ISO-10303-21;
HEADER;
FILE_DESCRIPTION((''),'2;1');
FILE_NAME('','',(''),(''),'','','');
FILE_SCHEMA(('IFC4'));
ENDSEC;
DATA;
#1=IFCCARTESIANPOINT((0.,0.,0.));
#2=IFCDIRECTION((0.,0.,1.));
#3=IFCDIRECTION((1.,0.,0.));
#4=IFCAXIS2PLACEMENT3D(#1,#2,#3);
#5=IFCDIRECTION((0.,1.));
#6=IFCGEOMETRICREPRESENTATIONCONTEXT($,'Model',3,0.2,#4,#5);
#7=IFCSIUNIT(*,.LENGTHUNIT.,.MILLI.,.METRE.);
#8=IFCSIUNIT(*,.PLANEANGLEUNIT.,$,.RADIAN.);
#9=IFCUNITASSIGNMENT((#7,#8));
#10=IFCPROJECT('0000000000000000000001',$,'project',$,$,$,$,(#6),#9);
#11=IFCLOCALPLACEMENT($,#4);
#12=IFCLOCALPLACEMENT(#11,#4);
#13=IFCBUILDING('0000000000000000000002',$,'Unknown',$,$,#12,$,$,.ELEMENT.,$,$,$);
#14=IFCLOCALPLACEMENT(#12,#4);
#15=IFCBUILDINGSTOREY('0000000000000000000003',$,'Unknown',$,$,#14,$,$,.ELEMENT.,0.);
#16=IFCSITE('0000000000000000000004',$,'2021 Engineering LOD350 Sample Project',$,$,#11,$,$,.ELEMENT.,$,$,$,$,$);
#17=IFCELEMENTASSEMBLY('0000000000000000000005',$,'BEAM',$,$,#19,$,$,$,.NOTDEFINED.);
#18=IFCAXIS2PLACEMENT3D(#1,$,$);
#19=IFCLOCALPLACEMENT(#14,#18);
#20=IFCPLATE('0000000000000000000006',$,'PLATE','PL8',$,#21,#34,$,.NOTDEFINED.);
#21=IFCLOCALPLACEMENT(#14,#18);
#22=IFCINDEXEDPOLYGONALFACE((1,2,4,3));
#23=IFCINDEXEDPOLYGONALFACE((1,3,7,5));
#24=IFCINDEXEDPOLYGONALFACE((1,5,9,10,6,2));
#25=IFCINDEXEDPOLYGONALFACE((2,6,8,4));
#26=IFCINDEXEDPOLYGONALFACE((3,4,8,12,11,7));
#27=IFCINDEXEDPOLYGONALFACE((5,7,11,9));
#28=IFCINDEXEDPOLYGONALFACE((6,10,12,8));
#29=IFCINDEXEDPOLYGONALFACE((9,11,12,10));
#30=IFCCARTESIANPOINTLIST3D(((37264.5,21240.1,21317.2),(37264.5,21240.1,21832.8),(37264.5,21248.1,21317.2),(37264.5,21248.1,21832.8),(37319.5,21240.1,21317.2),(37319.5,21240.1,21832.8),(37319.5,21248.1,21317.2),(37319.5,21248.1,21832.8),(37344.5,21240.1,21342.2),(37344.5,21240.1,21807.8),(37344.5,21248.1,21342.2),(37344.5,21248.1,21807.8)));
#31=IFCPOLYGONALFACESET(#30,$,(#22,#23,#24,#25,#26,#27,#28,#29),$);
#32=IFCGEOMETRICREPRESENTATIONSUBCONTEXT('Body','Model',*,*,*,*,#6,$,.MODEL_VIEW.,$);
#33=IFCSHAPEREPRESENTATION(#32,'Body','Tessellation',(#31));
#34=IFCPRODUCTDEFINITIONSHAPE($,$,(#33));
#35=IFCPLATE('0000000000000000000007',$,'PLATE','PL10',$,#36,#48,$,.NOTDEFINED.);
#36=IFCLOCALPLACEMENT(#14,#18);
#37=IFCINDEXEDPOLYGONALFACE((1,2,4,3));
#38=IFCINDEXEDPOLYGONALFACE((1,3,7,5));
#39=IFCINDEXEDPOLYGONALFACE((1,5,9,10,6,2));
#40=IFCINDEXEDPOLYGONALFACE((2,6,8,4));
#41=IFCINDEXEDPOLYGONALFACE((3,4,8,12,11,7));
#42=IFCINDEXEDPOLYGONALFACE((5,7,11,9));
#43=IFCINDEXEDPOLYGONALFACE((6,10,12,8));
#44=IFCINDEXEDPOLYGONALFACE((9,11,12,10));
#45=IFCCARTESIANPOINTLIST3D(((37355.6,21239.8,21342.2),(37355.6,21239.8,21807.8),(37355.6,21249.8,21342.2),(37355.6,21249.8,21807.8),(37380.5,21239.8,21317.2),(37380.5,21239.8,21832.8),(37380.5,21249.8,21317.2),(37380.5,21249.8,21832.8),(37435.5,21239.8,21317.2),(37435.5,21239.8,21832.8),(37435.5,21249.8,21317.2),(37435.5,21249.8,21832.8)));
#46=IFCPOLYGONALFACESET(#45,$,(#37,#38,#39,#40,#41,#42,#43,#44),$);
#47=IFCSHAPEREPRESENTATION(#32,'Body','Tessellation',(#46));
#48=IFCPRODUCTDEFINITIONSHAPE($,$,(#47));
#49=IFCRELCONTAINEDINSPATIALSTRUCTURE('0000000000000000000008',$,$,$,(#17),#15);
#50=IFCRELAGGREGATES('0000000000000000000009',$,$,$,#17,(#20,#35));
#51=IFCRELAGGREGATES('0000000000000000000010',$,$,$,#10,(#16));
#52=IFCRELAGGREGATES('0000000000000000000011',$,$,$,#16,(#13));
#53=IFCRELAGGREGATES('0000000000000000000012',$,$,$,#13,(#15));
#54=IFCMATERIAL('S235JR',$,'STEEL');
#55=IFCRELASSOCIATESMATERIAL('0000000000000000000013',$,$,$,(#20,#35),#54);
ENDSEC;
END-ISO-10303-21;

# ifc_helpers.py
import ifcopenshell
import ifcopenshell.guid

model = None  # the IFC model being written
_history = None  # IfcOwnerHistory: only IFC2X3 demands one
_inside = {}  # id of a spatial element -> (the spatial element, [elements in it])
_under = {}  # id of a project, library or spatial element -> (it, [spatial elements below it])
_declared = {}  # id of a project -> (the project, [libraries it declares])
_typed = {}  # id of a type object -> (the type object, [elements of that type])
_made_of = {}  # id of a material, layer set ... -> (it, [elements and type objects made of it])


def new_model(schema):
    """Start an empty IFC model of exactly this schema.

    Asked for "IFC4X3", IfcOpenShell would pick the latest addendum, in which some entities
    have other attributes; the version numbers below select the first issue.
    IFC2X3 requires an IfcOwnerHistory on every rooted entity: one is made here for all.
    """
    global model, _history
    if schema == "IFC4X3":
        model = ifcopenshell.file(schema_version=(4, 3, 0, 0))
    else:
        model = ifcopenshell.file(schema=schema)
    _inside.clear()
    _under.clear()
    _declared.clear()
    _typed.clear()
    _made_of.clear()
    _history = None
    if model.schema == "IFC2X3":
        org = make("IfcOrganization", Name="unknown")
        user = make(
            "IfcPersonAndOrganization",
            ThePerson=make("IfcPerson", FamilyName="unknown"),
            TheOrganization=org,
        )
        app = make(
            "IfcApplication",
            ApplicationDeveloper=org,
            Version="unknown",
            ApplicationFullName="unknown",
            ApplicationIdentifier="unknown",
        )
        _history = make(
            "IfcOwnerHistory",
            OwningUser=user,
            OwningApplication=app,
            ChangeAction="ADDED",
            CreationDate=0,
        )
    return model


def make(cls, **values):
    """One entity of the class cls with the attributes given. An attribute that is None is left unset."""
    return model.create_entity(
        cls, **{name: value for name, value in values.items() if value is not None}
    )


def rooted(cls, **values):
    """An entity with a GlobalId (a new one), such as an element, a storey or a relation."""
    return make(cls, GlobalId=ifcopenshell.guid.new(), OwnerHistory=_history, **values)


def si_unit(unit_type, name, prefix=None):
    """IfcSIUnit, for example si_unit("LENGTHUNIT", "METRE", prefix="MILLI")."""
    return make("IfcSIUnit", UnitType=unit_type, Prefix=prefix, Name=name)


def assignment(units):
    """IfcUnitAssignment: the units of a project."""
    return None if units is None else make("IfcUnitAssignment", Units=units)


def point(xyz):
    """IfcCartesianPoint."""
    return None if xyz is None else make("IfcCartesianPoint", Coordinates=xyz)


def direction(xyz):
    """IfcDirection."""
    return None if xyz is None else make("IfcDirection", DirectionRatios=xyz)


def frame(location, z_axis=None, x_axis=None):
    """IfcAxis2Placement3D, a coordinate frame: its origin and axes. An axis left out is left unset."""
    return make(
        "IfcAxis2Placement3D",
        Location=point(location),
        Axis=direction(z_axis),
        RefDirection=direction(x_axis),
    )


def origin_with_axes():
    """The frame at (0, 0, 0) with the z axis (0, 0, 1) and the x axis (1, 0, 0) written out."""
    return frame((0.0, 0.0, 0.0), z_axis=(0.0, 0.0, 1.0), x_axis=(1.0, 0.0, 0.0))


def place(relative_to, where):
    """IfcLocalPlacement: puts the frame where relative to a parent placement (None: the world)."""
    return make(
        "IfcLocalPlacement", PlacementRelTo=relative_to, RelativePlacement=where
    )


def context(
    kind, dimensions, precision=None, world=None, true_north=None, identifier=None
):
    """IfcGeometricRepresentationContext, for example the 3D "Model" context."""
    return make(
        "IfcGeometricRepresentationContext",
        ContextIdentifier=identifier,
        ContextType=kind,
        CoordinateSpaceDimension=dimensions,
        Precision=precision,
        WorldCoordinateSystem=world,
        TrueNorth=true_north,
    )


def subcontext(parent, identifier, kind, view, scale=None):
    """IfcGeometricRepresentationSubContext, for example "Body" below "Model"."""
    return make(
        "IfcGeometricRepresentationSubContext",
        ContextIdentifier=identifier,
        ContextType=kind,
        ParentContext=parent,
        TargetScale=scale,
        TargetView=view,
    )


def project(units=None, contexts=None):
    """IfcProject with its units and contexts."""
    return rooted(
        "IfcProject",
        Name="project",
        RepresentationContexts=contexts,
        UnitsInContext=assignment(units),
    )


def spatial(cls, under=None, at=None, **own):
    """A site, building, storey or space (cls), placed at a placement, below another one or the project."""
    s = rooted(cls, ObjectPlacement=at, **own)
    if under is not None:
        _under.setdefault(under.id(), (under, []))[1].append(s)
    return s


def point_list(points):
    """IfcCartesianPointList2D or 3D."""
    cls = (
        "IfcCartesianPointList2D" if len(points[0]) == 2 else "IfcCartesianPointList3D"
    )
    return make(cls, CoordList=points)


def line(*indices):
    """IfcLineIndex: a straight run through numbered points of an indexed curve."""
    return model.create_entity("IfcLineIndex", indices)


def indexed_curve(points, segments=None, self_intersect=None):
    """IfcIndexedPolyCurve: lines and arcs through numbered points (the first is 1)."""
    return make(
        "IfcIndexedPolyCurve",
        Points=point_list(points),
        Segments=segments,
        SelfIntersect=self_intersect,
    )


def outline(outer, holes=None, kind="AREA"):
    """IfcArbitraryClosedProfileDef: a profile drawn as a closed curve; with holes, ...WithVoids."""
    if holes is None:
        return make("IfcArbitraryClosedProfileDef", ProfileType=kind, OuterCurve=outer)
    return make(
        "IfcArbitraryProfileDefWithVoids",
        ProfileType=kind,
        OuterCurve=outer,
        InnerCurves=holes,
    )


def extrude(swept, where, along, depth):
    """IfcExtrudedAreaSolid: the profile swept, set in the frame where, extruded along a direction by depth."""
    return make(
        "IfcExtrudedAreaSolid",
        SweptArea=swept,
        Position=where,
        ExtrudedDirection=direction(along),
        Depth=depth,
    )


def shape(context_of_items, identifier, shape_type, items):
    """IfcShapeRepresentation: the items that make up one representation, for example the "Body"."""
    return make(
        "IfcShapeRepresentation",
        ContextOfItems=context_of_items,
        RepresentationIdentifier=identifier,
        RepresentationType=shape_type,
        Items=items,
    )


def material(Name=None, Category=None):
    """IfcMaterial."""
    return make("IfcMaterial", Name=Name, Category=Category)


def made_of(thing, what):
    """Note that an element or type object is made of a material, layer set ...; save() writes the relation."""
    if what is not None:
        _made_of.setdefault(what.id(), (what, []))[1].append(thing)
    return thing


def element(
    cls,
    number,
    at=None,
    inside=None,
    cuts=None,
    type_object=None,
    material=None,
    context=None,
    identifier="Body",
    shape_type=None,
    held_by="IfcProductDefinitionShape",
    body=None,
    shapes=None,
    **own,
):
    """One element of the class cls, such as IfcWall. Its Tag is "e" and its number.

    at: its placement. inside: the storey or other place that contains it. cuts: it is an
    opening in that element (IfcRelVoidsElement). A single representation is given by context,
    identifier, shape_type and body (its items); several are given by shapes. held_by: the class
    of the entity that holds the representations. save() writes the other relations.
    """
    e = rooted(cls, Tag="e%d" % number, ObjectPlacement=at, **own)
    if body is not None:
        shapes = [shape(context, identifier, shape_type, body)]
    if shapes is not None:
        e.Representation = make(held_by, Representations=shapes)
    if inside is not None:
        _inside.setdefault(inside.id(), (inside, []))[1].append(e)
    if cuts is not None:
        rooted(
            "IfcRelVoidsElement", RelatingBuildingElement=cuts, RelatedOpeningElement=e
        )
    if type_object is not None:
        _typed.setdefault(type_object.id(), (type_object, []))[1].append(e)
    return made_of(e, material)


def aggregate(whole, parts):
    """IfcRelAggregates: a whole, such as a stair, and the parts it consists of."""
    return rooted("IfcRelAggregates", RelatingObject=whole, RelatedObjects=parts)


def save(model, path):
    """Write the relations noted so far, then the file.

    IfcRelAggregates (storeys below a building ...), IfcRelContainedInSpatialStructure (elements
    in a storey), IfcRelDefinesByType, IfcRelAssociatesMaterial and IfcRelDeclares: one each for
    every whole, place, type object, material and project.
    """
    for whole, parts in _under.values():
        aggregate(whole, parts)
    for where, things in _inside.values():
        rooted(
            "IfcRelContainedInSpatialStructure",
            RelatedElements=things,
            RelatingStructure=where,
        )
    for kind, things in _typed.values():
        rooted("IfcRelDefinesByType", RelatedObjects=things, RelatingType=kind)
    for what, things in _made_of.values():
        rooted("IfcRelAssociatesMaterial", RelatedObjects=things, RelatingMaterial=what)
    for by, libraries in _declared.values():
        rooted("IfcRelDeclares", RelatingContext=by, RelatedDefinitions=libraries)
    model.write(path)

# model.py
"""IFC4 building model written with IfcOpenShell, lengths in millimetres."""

from ifc_helpers import new_model, si_unit, direction, frame, origin_with_axes, place, context, subcontext, project, spatial, line, indexed_curve, outline, extrude, material, element, aggregate, save


model = new_model("IFC4")

# Units and contexts
model_context = context("Model", 3, precision=0.2, world=origin_with_axes(), true_north=direction((0.0, 1.0)))
body_context = subcontext(model_context, "Body", "Model", "MODEL_VIEW")
ifc_project = project(units=[si_unit("LENGTHUNIT", "METRE", prefix="MILLI"), si_unit("PLANEANGLEUNIT", "RADIAN")], contexts=[model_context])

# Site, building, storey
site_placement = place(None, origin_with_axes())
site = spatial("IfcSite", under=ifc_project, at=site_placement, Name="2021 Engineering LOD350 Sample Project", CompositionType="ELEMENT")
building_placement = place(site_placement, origin_with_axes())
building = spatial("IfcBuilding", under=site, at=building_placement, Name="Unknown", CompositionType="ELEMENT")
storey_placement = place(building_placement, origin_with_axes())
storey = spatial("IfcBuildingStorey", under=building, at=storey_placement, Name="Unknown", CompositionType="ELEMENT", Elevation=0.0)

# Shared definitions
ifc_material_1 = material(Name="S235JR", Category="STEEL")

# Element assembly
assembly_1_placement = place(storey_placement, frame((37350.0, 18600.0, 21575.0), z_axis=(1.0, 0.0, 0.0), x_axis=(0.0, 1.0, 0.0)))
assembly_1 = element("IfcElementAssembly", 1, at=assembly_1_placement, inside=storey, Name="BEAM", PredefinedType="NOTDEFINED")

# Plates
plate_1_placement = place(assembly_1_placement, frame((2644.1, -257.8, -5.5), z_axis=(1.0, 0.0, 0.0), x_axis=(0.0, 0.0, -1.0)))
plate_1 = element("IfcPlate", 2, at=plate_1_placement, material=ifc_material_1, Name="PLATE", Description="PL8", PredefinedType="NOTDEFINED", context=body_context, shape_type="SolidModel", body=[
    extrude(outline(indexed_curve([(0.0, 25.0), (25.0, 0.0), (80.0, 0.0), (80.0, 515.6), (25.0, 515.6), (0.0, 490.6)], segments=[line(1, 2, 3, 4, 5, 6, 1)])), frame((0.0, 0.0, 4.0), z_axis=(0.0, 0.0, 1.0), x_axis=(1.0, 0.0, 0.0)), (0.0, 0.0, -1.0), 8.0),
])
plate_2_placement = place(assembly_1_placement, frame((2644.8, -257.8, 5.5), z_axis=(-1.0, 0.0, 0.0), x_axis=(0.0, 0.0, 1.0)))
plate_2 = element("IfcPlate", 3, at=plate_2_placement, material=ifc_material_1, Name="PLATE", Description="PL10", PredefinedType="NOTDEFINED", context=body_context, shape_type="SolidModel", body=[
    extrude(outline(indexed_curve([(0.0, 25.0), (25.0, 0.0), (80.0, 0.0), (80.0, 515.6), (25.0, 515.6), (0.0, 490.6)], segments=[line(1, 2, 3, 4, 5, 6, 1)])), frame((0.0, 0.0, 5.0), z_axis=(0.0, 0.0, 1.0), x_axis=(1.0, 0.0, 0.0)), (0.0, 0.0, -1.0), 10.0),
])

aggregate(assembly_1, [plate_1, plate_2])

save(model, "model.ifc")
